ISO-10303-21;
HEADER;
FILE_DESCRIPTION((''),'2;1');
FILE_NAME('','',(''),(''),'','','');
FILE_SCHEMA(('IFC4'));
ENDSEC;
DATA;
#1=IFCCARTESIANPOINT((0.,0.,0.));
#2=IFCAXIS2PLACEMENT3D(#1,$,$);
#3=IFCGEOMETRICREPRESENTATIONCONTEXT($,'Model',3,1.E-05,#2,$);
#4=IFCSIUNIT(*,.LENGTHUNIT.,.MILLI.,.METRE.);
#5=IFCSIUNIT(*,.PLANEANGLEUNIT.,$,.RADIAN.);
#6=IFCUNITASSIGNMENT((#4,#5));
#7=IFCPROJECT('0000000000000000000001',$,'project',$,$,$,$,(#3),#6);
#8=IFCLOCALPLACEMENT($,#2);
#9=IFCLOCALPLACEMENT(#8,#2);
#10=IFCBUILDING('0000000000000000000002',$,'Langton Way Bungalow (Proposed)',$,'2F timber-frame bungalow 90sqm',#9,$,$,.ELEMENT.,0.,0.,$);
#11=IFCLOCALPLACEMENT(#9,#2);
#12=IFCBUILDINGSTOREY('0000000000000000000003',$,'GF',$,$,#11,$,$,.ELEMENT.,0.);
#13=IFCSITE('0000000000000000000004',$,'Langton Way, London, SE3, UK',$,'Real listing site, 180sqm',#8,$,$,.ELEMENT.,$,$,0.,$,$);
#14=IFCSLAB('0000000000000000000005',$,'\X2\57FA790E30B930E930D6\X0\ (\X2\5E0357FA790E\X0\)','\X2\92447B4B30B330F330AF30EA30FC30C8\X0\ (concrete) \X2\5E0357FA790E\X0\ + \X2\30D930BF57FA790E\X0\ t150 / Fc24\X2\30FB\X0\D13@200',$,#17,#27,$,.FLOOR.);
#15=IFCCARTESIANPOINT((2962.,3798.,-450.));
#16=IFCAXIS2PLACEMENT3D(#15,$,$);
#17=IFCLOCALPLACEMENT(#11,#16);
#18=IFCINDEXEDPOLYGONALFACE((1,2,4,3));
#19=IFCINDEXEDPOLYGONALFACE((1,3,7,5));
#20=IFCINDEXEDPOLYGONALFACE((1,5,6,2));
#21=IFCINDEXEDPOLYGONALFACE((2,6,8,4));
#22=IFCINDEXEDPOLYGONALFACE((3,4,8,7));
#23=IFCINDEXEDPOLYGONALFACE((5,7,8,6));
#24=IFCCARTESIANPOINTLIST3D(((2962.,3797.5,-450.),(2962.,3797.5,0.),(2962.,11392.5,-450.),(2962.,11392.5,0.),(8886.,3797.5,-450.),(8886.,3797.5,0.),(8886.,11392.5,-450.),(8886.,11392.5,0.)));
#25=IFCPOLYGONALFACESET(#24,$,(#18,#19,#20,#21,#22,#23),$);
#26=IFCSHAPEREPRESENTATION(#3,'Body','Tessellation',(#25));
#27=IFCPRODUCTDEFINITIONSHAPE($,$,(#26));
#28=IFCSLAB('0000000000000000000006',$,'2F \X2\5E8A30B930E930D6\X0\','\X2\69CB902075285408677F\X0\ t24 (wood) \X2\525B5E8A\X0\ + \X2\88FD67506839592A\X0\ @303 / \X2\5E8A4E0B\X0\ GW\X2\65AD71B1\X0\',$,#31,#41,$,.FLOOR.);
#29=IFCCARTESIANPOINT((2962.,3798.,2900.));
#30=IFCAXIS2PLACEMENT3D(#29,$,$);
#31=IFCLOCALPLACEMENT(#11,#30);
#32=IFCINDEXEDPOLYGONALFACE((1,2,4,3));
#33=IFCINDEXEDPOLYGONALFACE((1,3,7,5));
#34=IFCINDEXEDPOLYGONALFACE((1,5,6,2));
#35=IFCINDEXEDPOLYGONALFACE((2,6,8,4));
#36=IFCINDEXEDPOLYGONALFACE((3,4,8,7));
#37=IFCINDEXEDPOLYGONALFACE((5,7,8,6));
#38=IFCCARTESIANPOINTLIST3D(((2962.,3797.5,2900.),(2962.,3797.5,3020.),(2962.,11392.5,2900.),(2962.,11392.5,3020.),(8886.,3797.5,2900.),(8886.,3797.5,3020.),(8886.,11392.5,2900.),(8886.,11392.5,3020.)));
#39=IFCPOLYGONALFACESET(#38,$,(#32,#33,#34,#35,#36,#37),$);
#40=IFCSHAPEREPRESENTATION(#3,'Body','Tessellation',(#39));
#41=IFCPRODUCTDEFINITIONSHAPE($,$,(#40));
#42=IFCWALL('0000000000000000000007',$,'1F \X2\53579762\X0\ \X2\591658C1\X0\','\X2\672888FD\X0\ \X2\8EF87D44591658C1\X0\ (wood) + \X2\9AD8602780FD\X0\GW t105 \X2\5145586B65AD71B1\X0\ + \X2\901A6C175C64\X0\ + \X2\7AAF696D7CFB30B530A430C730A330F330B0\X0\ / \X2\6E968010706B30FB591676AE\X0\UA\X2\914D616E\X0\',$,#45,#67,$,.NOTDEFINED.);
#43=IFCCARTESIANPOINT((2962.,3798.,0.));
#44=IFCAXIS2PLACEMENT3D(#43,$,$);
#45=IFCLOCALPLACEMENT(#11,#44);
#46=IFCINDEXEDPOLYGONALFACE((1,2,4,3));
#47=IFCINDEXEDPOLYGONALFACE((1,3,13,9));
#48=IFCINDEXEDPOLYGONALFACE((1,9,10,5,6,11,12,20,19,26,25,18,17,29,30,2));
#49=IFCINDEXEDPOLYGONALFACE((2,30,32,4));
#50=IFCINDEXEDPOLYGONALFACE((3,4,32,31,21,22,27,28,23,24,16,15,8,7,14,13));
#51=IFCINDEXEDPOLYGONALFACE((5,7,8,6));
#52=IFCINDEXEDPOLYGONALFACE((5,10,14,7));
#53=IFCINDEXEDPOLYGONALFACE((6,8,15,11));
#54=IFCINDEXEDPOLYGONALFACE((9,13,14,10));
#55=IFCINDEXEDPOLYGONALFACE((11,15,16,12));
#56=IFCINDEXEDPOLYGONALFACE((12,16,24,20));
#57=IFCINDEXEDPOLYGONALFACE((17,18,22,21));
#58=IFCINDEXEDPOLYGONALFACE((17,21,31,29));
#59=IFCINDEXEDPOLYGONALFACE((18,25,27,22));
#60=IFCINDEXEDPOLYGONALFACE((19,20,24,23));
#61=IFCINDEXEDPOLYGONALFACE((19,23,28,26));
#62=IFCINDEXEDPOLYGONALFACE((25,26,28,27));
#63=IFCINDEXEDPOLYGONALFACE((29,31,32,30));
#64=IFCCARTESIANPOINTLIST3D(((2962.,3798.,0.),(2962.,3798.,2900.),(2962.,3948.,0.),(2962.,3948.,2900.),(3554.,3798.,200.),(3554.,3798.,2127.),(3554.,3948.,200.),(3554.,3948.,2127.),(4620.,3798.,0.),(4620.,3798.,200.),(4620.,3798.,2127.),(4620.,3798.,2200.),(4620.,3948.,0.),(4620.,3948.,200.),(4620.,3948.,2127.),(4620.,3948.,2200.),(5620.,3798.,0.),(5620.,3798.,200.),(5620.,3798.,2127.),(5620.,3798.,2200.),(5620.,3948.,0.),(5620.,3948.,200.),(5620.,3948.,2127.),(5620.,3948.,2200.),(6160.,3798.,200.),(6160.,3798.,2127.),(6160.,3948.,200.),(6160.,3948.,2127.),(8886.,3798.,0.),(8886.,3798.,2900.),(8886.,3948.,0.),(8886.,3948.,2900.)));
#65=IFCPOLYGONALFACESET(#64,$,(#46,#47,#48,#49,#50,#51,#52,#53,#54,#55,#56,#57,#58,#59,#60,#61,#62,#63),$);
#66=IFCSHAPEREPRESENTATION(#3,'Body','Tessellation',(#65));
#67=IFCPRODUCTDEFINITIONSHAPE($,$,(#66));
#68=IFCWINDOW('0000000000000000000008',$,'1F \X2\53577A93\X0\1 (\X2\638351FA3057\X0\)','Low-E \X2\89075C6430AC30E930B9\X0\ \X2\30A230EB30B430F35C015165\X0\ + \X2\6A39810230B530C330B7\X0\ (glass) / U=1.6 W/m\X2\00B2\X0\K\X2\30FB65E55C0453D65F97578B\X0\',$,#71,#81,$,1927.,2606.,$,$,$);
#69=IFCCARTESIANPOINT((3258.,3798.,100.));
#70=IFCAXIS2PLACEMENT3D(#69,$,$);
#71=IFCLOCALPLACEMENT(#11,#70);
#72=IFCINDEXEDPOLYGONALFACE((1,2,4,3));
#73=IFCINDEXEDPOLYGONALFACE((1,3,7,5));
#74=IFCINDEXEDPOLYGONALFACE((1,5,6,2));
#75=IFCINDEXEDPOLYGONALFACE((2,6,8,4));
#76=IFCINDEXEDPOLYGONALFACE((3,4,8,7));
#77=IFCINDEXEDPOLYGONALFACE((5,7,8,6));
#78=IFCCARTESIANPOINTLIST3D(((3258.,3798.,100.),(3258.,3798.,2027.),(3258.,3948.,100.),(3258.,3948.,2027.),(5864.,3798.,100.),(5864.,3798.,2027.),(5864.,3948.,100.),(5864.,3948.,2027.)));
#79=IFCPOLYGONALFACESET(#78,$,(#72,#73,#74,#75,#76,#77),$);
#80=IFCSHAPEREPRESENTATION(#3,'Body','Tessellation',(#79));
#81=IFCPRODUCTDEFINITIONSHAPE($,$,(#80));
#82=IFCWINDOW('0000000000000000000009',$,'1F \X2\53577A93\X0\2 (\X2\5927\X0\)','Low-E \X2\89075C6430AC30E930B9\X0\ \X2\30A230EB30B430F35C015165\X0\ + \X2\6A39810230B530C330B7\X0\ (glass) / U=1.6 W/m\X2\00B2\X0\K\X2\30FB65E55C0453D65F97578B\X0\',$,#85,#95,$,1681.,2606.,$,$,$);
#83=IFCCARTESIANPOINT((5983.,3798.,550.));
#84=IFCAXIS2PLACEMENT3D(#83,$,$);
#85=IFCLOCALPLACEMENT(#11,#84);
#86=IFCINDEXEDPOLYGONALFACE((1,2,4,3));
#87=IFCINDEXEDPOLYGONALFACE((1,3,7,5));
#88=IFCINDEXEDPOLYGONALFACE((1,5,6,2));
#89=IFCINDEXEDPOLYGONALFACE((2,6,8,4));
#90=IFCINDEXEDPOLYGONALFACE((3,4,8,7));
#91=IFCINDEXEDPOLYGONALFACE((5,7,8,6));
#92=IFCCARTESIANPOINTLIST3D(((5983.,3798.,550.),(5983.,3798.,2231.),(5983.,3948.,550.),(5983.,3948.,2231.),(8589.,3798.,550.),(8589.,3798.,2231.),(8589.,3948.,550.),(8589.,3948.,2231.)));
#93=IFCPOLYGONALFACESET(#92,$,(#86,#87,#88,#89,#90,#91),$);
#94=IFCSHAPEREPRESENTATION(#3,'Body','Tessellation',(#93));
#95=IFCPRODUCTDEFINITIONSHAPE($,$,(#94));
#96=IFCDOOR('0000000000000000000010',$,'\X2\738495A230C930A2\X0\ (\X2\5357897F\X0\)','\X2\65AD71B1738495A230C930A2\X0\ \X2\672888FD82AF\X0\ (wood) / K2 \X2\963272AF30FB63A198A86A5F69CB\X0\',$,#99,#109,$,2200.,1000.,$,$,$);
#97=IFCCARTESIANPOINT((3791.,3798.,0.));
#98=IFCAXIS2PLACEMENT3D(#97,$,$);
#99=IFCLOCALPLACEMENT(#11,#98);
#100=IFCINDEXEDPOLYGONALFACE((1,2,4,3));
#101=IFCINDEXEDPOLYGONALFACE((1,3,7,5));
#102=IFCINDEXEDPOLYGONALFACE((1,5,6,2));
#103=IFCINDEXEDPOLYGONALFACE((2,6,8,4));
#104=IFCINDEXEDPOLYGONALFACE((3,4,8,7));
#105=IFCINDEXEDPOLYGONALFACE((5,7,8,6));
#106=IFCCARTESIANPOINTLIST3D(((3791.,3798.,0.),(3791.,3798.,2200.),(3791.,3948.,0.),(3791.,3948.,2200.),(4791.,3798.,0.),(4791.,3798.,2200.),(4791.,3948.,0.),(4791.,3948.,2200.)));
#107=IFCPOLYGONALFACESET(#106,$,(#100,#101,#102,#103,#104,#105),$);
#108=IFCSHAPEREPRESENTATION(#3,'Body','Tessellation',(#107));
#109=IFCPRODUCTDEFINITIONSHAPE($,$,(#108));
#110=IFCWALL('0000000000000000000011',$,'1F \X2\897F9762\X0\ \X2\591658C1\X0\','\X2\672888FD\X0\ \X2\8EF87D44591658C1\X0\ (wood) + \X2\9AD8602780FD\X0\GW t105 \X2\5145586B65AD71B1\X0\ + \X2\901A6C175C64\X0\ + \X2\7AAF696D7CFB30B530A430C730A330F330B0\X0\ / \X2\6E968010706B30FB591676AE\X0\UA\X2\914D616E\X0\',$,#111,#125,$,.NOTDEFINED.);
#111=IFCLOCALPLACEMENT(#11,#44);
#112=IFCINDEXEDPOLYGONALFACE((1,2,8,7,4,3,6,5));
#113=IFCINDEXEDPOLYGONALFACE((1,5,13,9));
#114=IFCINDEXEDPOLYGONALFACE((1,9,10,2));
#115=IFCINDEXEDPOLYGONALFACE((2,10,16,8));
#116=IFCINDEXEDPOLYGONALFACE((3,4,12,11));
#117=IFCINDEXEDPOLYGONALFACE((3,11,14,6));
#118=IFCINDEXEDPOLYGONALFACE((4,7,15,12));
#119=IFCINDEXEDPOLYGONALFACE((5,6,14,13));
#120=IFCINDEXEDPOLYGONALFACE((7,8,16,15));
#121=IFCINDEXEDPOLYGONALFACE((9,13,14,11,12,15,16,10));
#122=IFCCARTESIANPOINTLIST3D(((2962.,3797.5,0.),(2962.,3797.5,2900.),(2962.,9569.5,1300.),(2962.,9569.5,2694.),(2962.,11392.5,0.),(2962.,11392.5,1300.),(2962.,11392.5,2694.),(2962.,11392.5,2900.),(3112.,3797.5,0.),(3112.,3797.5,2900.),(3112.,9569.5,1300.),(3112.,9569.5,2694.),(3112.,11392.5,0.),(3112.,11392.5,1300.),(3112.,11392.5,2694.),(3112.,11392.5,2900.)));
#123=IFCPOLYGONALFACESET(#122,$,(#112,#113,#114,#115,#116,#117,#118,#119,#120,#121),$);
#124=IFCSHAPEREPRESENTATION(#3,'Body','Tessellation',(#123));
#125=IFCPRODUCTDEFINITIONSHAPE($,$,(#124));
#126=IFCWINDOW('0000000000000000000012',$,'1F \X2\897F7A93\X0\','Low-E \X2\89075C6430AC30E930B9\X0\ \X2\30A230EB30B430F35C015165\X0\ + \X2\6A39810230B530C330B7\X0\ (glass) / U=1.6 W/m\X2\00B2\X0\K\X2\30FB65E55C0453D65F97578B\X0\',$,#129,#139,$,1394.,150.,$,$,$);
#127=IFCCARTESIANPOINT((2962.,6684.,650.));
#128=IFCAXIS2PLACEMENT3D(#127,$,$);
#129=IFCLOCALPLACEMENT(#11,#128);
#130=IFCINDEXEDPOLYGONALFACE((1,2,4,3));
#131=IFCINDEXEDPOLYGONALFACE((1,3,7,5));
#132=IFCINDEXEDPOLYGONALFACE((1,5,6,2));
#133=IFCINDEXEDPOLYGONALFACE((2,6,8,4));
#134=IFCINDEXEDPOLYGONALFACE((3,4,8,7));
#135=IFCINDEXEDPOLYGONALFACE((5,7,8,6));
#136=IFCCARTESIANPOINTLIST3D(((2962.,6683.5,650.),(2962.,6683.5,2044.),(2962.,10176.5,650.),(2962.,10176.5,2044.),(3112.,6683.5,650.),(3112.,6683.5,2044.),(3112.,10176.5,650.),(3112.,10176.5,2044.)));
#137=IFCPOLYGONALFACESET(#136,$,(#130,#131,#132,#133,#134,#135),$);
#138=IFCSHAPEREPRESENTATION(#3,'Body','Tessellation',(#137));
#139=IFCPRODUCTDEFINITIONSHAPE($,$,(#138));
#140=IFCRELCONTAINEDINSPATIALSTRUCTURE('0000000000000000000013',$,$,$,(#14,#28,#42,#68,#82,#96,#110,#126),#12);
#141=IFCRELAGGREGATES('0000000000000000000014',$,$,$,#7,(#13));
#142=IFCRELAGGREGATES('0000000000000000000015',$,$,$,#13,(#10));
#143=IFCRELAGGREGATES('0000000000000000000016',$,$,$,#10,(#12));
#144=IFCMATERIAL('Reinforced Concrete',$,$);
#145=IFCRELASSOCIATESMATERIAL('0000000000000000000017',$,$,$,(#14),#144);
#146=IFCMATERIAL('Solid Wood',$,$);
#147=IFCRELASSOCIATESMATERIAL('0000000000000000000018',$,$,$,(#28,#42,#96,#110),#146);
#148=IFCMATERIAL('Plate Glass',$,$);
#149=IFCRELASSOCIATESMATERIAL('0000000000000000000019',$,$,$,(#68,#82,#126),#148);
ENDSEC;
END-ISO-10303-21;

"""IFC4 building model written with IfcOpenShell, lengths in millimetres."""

from ifc_helpers import new_model, si_unit, frame, frame_2d, origin, place, context, project, spatial, rectangle, extrude, material, element, fill, save


model = new_model("IFC4")

# Units and contexts
model_context = context("Model", 3, precision=1e-05, world=origin())
ifc_project = project(units=[si_unit("LENGTHUNIT", "METRE", prefix="MILLI"), si_unit("PLANEANGLEUNIT", "RADIAN")], contexts=[model_context])

# Site, building, storey
site_placement = place(None, origin())
site = spatial("IfcSite", under=ifc_project, at=site_placement, Name="Langton Way, London, SE3, UK", ObjectType="Real listing site, 180sqm", CompositionType="ELEMENT", RefElevation=0.0)
building_placement = place(site_placement, origin())
building = spatial("IfcBuilding", under=site, at=building_placement, Name="Langton Way Bungalow (Proposed)", ObjectType="2F timber-frame bungalow 90sqm", CompositionType="ELEMENT", ElevationOfRefHeight=0.0, ElevationOfTerrain=0.0)
storey_placement = place(building_placement, origin())
storey = spatial("IfcBuildingStorey", under=building, at=storey_placement, Name="GF", CompositionType="ELEMENT", Elevation=0.0)

# Slabs
ifc_material_1 = material(Name="Reinforced Concrete")
slab_1_placement = place(storey_placement, frame((2962.0, 3798.0, -450.0)))
element("IfcSlab", 1, at=slab_1_placement, inside=storey, material=ifc_material_1, Name="基礎スラブ (布基礎)", Description="鉄筋コンクリート (concrete) 布基礎 + ベタ基礎 t150 / Fc24・D13@200", PredefinedType="FLOOR", context=model_context, shape_type="SweptSolid", body=[
    extrude(rectangle(XDim=5924.0, YDim=7595.0, at=frame_2d((2962.0, 3797.0))), frame((2962.0, 3798.0, -450.0)), (0.0, 0.0, 1.0), 450.0),
])
ifc_material_2 = material(Name="Solid Wood")
slab_2_placement = place(storey_placement, frame((2962.0, 3798.0, 2900.0)))
element("IfcSlab", 2, at=slab_2_placement, inside=storey, material=ifc_material_2, Name="2F 床スラブ", Description="構造用合板 t24 (wood) 剛床 + 製材根太 @303 / 床下 GW断熱", PredefinedType="FLOOR", context=model_context, shape_type="SweptSolid", body=[
    extrude(rectangle(XDim=5924.0, YDim=7595.0, at=frame_2d((2962.0, 3797.0))), frame((2962.0, 3798.0, 2900.0)), (0.0, 0.0, 1.0), 120.0),
])

# Wall, openings, windows, door
wall_1_placement = place(storey_placement, frame((2962.0, 3798.0, 0.0)))
wall_1 = element("IfcWall", 3, at=wall_1_placement, inside=storey, material=ifc_material_2, Name="1F 南面 外壁", Description="木製 軸組外壁 (wood) + 高性能GW t105 充填断熱 + 通気層 + 窯業系サイディング / 準耐火・外皮UA配慮", PredefinedType="NOTDEFINED", context=model_context, shape_type="SweptSolid", body=[
    extrude(rectangle(XDim=5924.0, YDim=150.0, at=frame_2d((2962.0, 75.0))), frame((2962.0, 3798.0, 0.0)), (0.0, 0.0, 1.0), 2900.0),
])
opening_1_placement = place(storey_placement, frame((3258.0, 3798.0, 100.0)))
opening_1 = element("IfcOpeningElement", 4, at=opening_1_placement, cuts=wall_1, PredefinedType="NOTDEFINED", context=model_context, shape_type="SweptSolid", body=[
    extrude(rectangle(XDim=2606.0, YDim=150.0, at=frame_2d((1303.0, 75.0))), frame((3258.0, 3798.0, 100.0)), (0.0, 0.0, 1.0), 1927.0),
])
opening_2_placement = place(storey_placement, frame((5983.0, 3798.0, 550.0)))
opening_2 = element("IfcOpeningElement", 5, at=opening_2_placement, cuts=wall_1, PredefinedType="NOTDEFINED", context=model_context, shape_type="SweptSolid", body=[
    extrude(rectangle(XDim=2606.0, YDim=150.0, at=frame_2d((1303.0, 75.0))), frame((5983.0, 3798.0, 550.0)), (0.0, 0.0, 1.0), 1681.0),
])
opening_3_placement = place(storey_placement, frame((3791.0, 3798.0, 0.0)))
opening_3 = element("IfcOpeningElement", 6, at=opening_3_placement, cuts=wall_1, PredefinedType="NOTDEFINED", context=model_context, shape_type="SweptSolid", body=[
    extrude(rectangle(XDim=1000.0, YDim=150.0, at=frame_2d((500.0, 75.0))), frame((3791.0, 3798.0, 0.0)), (0.0, 0.0, 1.0), 2200.0),
])
ifc_material_3 = material(Name="Plate Glass")
window_1_placement = place(storey_placement, frame((3258.0, 3798.0, 100.0)))
window_1 = element("IfcWindow", 7, at=window_1_placement, inside=storey, material=ifc_material_3, Name="1F 南窓1 (掃出し)", Description="Low-E 複層ガラス アルゴン封入 + 樹脂サッシ (glass) / U=1.6 W/m²K・日射取得型", OverallHeight=1927.0, OverallWidth=2606.0, context=model_context, shape_type="SweptSolid", body=[
    extrude(rectangle(XDim=2606.0, YDim=150.0, at=frame_2d((1303.0, 75.0))), frame((3258.0, 3798.0, 100.0)), (0.0, 0.0, 1.0), 1927.0),
])
fill(opening_1, window_1)
window_2_placement = place(storey_placement, frame((5983.0, 3798.0, 550.0)))
window_2 = element("IfcWindow", 8, at=window_2_placement, inside=storey, material=ifc_material_3, Name="1F 南窓2 (大)", Description="Low-E 複層ガラス アルゴン封入 + 樹脂サッシ (glass) / U=1.6 W/m²K・日射取得型", OverallHeight=1681.0, OverallWidth=2606.0, context=model_context, shape_type="SweptSolid", body=[
    extrude(rectangle(XDim=2606.0, YDim=150.0, at=frame_2d((1303.0, 75.0))), frame((5983.0, 3798.0, 550.0)), (0.0, 0.0, 1.0), 1681.0),
])
fill(opening_2, window_2)
door_placement = place(storey_placement, frame((3791.0, 3798.0, 0.0)))
door = element("IfcDoor", 9, at=door_placement, inside=storey, material=ifc_material_2, Name="玄関ドア (南西)", Description="断熱玄関ドア 木製芯 (wood) / K2 防犯・採風機構", OverallHeight=2200.0, OverallWidth=1000.0, context=model_context, shape_type="SweptSolid", body=[
    extrude(rectangle(XDim=1000.0, YDim=150.0, at=frame_2d((500.0, 75.0))), frame((3791.0, 3798.0, 0.0)), (0.0, 0.0, 1.0), 2200.0),
])
fill(opening_3, door)

# Wall, opening, window
wall_2_placement = place(storey_placement, frame((2962.0, 3798.0, 0.0)))
wall_2 = element("IfcWall", 10, at=wall_2_placement, inside=storey, material=ifc_material_2, Name="1F 西面 外壁", Description="木製 軸組外壁 (wood) + 高性能GW t105 充填断熱 + 通気層 + 窯業系サイディング / 準耐火・外皮UA配慮", PredefinedType="NOTDEFINED", context=model_context, shape_type="SweptSolid", body=[
    extrude(rectangle(XDim=150.0, YDim=7595.0, at=frame_2d((75.0, 3797.0))), frame((2962.0, 3798.0, 0.0)), (0.0, 0.0, 1.0), 2900.0),
])
opening_4_placement = place(storey_placement, frame((2962.0, 6684.0, 650.0)))
opening_4 = element("IfcOpeningElement", 11, at=opening_4_placement, cuts=wall_2, PredefinedType="NOTDEFINED", context=model_context, shape_type="SweptSolid", body=[
    extrude(rectangle(XDim=150.0, YDim=3493.0, at=frame_2d((75.0, 1746.0))), frame((2962.0, 6684.0, 650.0)), (0.0, 0.0, 1.0), 1394.0),
])
window_3_placement = place(storey_placement, frame((2962.0, 6684.0, 650.0)))
window_3 = element("IfcWindow", 12, at=window_3_placement, inside=storey, material=ifc_material_3, Name="1F 西窓", Description="Low-E 複層ガラス アルゴン封入 + 樹脂サッシ (glass) / U=1.6 W/m²K・日射取得型", OverallHeight=1394.0, OverallWidth=150.0, context=model_context, shape_type="SweptSolid", body=[
    extrude(rectangle(XDim=150.0, YDim=3493.0, at=frame_2d((75.0, 1746.0))), frame((2962.0, 6684.0, 650.0)), (0.0, 0.0, 1.0), 1394.0),
])
fill(opening_4, window_3)

save(model, "model.ifc")
